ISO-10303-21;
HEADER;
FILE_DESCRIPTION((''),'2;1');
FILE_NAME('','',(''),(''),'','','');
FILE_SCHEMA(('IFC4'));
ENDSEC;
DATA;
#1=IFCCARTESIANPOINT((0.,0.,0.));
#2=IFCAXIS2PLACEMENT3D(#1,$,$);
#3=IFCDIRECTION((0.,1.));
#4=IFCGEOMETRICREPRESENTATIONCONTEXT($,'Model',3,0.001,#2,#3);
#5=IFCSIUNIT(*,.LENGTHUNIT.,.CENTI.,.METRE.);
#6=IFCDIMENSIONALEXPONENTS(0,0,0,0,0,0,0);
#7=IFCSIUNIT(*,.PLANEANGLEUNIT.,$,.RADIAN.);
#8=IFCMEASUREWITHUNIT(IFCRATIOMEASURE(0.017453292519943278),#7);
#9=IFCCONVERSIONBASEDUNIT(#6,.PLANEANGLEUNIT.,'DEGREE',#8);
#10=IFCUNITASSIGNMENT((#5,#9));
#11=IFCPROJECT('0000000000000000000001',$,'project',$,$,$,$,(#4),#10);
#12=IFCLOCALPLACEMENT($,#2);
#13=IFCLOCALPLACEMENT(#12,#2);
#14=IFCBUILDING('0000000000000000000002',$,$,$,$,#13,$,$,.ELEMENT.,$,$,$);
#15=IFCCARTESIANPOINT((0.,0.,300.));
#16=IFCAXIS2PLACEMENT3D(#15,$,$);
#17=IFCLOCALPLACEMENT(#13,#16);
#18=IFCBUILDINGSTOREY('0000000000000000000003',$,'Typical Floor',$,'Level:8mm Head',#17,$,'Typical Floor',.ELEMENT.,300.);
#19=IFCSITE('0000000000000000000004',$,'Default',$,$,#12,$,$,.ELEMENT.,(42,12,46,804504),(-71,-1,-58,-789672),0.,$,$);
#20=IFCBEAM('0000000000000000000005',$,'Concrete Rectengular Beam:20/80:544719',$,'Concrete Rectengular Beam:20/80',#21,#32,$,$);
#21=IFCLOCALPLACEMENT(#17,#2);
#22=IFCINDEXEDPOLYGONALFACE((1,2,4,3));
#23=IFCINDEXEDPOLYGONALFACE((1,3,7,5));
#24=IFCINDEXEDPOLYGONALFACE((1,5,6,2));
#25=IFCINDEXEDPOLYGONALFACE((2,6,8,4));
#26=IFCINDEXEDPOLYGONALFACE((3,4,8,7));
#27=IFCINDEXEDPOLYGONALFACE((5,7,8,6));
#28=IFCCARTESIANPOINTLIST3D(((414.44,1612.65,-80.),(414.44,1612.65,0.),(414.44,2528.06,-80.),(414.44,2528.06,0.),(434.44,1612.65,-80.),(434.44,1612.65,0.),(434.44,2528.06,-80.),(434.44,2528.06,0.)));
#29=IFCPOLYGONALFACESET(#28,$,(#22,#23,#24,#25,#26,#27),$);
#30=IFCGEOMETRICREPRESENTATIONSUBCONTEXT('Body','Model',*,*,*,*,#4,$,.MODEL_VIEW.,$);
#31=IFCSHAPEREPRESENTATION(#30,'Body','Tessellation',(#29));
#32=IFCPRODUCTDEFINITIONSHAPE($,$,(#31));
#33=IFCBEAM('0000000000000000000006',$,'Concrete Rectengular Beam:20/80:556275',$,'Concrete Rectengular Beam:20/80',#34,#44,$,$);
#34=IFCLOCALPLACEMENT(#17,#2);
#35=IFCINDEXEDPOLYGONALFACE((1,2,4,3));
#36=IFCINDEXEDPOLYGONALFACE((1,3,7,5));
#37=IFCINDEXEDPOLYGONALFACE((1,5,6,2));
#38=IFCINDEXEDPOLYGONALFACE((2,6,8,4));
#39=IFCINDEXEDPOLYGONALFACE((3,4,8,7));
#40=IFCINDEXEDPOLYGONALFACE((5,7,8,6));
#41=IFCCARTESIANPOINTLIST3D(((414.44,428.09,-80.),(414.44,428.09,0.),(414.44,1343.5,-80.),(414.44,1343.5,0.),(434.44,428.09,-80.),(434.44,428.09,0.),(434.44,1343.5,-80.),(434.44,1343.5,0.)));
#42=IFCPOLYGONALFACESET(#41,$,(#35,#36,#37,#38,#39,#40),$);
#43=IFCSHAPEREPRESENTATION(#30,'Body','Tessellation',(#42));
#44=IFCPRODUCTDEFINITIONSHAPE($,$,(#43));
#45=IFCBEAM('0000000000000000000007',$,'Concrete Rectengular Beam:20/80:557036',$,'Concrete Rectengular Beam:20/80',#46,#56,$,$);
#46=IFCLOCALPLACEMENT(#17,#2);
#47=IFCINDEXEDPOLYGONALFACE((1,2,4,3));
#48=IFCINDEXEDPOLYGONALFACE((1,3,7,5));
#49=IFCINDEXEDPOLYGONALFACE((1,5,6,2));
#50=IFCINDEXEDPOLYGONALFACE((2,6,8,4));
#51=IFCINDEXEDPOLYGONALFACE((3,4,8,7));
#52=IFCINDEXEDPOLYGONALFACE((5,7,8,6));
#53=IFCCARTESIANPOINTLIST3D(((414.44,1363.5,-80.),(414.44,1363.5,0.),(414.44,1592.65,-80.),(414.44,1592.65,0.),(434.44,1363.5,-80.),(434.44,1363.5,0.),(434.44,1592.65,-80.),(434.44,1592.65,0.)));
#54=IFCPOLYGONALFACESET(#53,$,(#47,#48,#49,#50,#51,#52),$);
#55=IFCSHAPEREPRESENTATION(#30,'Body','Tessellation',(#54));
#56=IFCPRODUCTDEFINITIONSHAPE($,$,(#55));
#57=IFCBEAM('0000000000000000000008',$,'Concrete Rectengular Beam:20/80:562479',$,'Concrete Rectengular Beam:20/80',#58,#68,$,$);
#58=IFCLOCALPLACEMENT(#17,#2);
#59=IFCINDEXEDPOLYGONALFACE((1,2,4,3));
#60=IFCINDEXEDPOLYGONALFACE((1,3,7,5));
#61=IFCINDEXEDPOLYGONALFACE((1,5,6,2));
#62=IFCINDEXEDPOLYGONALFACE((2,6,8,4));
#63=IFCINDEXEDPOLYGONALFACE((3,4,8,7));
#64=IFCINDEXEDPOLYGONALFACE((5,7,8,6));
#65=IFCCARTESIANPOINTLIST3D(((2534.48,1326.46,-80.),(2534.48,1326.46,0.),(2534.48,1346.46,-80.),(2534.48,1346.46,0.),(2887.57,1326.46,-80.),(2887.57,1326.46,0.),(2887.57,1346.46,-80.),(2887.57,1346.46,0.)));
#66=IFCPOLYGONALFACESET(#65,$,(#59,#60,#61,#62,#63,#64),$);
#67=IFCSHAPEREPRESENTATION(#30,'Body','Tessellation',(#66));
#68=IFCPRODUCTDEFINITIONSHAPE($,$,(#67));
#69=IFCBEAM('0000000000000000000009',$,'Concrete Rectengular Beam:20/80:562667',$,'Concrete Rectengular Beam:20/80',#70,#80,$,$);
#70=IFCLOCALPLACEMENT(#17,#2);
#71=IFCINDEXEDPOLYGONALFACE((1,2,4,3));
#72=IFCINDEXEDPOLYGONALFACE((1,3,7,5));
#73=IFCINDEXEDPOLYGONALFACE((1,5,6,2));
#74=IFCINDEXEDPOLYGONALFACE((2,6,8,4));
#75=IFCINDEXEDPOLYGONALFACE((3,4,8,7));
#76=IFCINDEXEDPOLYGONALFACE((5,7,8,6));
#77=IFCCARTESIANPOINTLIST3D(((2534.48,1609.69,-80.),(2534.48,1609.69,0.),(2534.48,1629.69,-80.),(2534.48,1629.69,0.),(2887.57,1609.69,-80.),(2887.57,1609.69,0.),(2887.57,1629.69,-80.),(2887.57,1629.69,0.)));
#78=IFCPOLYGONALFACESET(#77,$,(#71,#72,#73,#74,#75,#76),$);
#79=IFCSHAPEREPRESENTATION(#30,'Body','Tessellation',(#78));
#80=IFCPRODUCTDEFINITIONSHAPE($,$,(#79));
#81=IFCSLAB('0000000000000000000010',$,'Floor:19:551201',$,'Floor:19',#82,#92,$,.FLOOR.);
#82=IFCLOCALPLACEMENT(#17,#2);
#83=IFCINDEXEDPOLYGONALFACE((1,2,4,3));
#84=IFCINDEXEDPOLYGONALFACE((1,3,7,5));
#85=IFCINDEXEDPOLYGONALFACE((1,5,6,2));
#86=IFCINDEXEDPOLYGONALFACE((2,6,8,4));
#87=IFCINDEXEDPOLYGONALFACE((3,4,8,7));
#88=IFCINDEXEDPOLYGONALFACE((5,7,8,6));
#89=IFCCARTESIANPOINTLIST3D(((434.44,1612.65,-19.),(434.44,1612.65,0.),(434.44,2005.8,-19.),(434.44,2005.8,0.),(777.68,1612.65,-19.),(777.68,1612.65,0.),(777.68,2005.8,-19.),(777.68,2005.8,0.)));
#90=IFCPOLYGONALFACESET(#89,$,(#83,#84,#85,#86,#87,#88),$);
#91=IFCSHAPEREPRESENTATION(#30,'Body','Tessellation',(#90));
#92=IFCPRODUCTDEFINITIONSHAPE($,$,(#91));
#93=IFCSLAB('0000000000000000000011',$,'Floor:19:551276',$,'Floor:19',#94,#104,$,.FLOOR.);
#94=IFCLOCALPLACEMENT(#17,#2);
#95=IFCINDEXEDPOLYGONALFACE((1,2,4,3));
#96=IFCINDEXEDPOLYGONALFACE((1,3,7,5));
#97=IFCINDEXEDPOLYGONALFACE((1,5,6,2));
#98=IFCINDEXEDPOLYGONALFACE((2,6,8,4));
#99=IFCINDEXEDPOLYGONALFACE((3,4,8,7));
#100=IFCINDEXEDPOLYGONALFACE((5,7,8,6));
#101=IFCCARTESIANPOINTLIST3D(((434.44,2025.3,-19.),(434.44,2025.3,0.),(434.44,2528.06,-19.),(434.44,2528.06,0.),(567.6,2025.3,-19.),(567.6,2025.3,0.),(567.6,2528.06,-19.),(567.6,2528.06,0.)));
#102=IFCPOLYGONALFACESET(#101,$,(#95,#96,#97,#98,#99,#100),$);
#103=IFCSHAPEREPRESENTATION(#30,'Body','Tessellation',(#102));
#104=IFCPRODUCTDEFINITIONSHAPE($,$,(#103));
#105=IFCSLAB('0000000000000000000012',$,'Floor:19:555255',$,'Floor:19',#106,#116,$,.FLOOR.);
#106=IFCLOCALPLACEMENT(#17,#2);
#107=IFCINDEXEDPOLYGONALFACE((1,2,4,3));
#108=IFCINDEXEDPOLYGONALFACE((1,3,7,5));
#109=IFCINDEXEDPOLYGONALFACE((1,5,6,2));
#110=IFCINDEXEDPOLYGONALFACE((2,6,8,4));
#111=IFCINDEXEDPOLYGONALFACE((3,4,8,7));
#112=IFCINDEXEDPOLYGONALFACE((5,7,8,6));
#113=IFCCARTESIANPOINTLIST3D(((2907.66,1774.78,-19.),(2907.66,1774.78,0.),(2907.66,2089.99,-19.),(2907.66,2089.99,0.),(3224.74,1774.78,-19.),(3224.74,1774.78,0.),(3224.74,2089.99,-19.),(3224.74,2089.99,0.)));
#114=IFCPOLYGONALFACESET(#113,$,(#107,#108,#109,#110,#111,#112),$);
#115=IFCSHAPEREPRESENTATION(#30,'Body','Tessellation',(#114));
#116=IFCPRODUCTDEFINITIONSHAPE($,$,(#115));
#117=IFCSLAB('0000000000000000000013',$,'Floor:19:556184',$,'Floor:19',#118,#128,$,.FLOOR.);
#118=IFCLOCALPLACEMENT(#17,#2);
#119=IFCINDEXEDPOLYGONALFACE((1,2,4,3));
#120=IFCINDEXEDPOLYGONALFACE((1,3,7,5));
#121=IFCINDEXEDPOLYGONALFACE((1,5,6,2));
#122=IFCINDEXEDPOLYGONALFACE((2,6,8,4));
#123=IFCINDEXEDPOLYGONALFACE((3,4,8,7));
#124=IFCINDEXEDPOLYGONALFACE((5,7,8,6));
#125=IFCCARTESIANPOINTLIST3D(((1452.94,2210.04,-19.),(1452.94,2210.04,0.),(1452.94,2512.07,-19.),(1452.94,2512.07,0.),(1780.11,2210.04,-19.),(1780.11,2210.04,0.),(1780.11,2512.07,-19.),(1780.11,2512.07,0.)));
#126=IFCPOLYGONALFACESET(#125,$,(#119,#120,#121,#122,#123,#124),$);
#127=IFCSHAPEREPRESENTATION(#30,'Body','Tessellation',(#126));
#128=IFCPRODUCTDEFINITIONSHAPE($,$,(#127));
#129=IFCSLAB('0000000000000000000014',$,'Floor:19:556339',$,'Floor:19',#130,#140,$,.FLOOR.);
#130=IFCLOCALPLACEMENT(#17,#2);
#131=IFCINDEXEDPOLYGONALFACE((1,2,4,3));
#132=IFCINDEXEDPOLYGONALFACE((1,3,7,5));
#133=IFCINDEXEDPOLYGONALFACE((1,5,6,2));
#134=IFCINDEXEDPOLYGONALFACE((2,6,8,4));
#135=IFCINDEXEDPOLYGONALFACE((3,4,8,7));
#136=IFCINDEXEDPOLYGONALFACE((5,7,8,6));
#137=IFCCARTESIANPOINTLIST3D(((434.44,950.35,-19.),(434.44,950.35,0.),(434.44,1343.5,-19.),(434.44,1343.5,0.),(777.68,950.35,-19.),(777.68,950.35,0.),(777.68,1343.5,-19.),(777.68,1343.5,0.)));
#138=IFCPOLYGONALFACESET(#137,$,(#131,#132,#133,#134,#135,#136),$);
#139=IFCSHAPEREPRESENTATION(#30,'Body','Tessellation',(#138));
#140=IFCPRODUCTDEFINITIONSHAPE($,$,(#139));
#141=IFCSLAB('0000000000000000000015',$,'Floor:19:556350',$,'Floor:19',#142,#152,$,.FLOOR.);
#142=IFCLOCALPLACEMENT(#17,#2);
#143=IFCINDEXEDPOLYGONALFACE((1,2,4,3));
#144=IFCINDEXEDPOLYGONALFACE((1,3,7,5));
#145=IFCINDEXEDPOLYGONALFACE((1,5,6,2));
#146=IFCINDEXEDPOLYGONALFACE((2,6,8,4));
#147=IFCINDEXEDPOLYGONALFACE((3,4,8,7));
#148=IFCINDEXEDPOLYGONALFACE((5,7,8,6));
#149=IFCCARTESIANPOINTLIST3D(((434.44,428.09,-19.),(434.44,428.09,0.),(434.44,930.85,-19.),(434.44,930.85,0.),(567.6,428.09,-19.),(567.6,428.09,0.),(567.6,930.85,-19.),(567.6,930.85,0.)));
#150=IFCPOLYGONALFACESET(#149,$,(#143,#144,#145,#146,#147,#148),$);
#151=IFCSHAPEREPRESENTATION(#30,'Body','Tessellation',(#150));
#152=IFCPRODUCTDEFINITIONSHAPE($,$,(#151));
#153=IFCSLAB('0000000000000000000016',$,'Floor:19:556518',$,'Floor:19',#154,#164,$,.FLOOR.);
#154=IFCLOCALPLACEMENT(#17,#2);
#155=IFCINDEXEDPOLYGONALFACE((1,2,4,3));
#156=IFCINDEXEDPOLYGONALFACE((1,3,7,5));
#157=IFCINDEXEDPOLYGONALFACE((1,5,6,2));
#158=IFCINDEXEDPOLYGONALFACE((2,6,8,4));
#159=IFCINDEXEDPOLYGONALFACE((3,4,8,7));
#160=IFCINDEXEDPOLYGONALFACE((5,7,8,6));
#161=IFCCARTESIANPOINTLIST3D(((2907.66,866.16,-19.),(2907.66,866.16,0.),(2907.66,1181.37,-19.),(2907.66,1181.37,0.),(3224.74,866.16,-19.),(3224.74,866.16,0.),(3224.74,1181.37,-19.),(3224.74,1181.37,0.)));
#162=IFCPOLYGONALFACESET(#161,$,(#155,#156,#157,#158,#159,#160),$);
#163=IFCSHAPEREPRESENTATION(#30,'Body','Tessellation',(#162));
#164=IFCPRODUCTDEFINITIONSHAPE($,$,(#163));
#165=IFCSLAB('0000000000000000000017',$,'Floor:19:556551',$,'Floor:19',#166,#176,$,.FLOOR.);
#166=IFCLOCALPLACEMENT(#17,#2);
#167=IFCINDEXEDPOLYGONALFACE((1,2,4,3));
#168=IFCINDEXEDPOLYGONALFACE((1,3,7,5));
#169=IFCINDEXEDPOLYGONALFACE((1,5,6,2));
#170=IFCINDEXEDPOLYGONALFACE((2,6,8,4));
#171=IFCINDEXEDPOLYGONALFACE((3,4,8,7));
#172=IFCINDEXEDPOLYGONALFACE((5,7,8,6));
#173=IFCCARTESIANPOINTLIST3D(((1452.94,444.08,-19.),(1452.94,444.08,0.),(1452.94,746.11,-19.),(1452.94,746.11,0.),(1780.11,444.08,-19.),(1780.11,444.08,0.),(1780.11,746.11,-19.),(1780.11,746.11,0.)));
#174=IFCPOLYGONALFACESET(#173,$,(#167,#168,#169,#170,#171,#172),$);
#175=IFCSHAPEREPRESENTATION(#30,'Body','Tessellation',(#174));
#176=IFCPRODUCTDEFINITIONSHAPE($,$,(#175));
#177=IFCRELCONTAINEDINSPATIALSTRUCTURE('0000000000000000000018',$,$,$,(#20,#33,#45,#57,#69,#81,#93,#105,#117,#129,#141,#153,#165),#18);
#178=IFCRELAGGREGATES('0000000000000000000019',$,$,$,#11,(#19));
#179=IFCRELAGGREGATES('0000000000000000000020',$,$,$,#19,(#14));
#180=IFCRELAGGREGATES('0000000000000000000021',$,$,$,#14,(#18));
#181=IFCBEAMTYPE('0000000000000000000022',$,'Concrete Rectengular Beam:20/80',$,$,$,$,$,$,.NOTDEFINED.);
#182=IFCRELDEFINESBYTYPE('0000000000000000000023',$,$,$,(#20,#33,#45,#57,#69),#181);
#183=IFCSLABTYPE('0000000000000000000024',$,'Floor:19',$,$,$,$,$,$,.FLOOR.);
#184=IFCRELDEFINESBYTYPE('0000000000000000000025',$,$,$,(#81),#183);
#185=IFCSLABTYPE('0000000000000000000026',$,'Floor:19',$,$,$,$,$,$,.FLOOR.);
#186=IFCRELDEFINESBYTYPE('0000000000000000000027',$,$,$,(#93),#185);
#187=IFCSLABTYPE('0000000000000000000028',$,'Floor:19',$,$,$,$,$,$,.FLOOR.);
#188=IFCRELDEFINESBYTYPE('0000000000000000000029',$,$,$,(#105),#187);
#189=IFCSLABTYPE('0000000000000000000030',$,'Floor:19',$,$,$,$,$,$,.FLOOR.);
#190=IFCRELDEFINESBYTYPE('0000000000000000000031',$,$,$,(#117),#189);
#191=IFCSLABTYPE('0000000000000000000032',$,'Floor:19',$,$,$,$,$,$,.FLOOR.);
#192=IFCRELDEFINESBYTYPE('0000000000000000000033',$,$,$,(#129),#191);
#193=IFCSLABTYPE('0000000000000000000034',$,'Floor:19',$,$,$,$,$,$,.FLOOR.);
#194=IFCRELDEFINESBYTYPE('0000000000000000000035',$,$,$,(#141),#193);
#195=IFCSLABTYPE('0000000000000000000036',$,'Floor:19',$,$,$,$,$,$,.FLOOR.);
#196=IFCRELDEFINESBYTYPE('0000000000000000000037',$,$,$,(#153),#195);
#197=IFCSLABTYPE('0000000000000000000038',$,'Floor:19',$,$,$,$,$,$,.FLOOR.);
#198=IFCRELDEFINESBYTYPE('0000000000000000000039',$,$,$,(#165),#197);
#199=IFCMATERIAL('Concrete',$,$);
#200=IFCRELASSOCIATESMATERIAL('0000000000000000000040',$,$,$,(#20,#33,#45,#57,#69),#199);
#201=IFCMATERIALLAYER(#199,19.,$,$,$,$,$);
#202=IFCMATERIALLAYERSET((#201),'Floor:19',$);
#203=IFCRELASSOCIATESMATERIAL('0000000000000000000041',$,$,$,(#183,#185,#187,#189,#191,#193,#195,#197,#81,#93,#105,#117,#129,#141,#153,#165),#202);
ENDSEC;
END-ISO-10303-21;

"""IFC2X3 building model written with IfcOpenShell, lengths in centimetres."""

from ifc_helpers import new_model, entity, si_unit, converted_unit, direction, frame, frame_2d, origin, origin_2d_with_axis, place, context, subcontext, project, spatial, rectangle, extrude, material, layer, layer_set, layer_usage, type_object, element, save


model = new_model("IFC2X3")

# Units and contexts
model_context = context("Model", 3, precision=0.001, world=origin(), true_north=direction((0.0, 1.0)))
body_context = subcontext(model_context, "Body", "Model", "MODEL_VIEW")
ifc_project = project(units=[si_unit("LENGTHUNIT", "METRE", prefix="CENTI"), converted_unit("PLANEANGLEUNIT", "DEGREE", entity("IfcRatioMeasure", 0.017453292519943278), si_unit("PLANEANGLEUNIT", "RADIAN"), dimensions=[0, 0, 0, 0, 0, 0, 0])], contexts=[model_context])

# Site, building, storey
site_placement = place(None, origin())
site = spatial("IfcSite", under=ifc_project, at=site_placement, Name="Default", CompositionType="ELEMENT", RefLatitude=(42, 12, 46, 804504), RefLongitude=(-71, -1, -58, -789672), RefElevation=0.0)
building_placement = place(site_placement, origin())
building = spatial("IfcBuilding", under=site, at=building_placement, CompositionType="ELEMENT")
storey_placement = place(building_placement, frame((0.0, 0.0, 300.0)))
storey = spatial("IfcBuildingStorey", under=building, at=storey_placement, Name="Typical Floor", ObjectType="Level:8mm Head", LongName="Typical Floor", CompositionType="ELEMENT", Elevation=300.0)

# Beams
ifc_material = material(Name="Concrete")
beam_type_1 = type_object("IfcBeamType", Name="Concrete Rectengular Beam:20/80", PredefinedType="NOTDEFINED")
beam_1_placement = place(storey_placement, frame((424.44, 1602.65, 0.0), z_axis=(0.0, 0.0, 1.0), x_axis=(0.0, 1.0, 0.0)))
element("IfcBeam", 1, at=beam_1_placement, inside=storey, type_object=beam_type_1, material=ifc_material, Name="Concrete Rectengular Beam:20/80:544719", ObjectType="Concrete Rectengular Beam:20/80", context=body_context, shape_type="SweptSolid", body=[
    extrude(rectangle(XDim=80.0, YDim=20.0, at=frame_2d((0.0, 0.0), x_axis=(1.0, 0.0))), frame((10.0, 0.0, -40.0), z_axis=(1.0, 0.0, 0.0), x_axis=(0.0, 0.0, -1.0)), (0.0, 0.0, 1.0), 915.41),
])
beam_2_placement = place(storey_placement, frame((424.44, 1353.5, 0.0), z_axis=(0.0, 0.0, 1.0), x_axis=(0.0, -1.0, 0.0)))
element("IfcBeam", 2, at=beam_2_placement, inside=storey, type_object=beam_type_1, material=ifc_material, Name="Concrete Rectengular Beam:20/80:556275", ObjectType="Concrete Rectengular Beam:20/80", context=body_context, shape_type="SweptSolid", body=[
    extrude(rectangle(XDim=80.0, YDim=20.0, at=frame_2d((0.0, 0.0), x_axis=(1.0, 0.0))), frame((10.0, 0.0, -40.0), z_axis=(1.0, 0.0, 0.0), x_axis=(0.0, 0.0, -1.0)), (0.0, 0.0, 1.0), 915.41),
])
beam_3_placement = place(storey_placement, frame((424.44, 1353.5, 0.0), z_axis=(0.0, 0.0, 1.0), x_axis=(0.0, 1.0, 0.0)))
element("IfcBeam", 3, at=beam_3_placement, inside=storey, type_object=beam_type_1, material=ifc_material, Name="Concrete Rectengular Beam:20/80:557036", ObjectType="Concrete Rectengular Beam:20/80", context=body_context, shape_type="SweptSolid", body=[
    extrude(rectangle(XDim=80.0, YDim=20.0, at=frame_2d((0.0, 0.0), x_axis=(1.0, 0.0))), frame((10.0, 0.0, -40.0), z_axis=(1.0, 0.0, 0.0), x_axis=(0.0, 0.0, -1.0)), (0.0, 0.0, 1.0), 229.14),
])
beam_4_placement = place(storey_placement, frame((2897.57, 1336.46, 0.0), z_axis=(0.0, 0.0, 1.0), x_axis=(-1.0, 0.0, 0.0)))
element("IfcBeam", 4, at=beam_4_placement, inside=storey, type_object=beam_type_1, material=ifc_material, Name="Concrete Rectengular Beam:20/80:562479", ObjectType="Concrete Rectengular Beam:20/80", context=body_context, shape_type="SweptSolid", body=[
    extrude(rectangle(XDim=80.0, YDim=20.0, at=frame_2d((0.0, 0.0), x_axis=(1.0, 0.0))), frame((10.0, 0.0, -40.0), z_axis=(1.0, 0.0, 0.0), x_axis=(0.0, 0.0, -1.0)), (0.0, 0.0, 1.0), 353.09),
])
beam_5_placement = place(storey_placement, frame((2897.57, 1619.69, 0.0), z_axis=(0.0, 0.0, 1.0), x_axis=(-1.0, 0.0, 0.0)))
element("IfcBeam", 5, at=beam_5_placement, inside=storey, type_object=beam_type_1, material=ifc_material, Name="Concrete Rectengular Beam:20/80:562667", ObjectType="Concrete Rectengular Beam:20/80", context=body_context, shape_type="SweptSolid", body=[
    extrude(rectangle(XDim=80.0, YDim=20.0, at=frame_2d((0.0, 0.0), x_axis=(1.0, 0.0))), frame((10.0, 0.0, -40.0), z_axis=(1.0, 0.0, 0.0), x_axis=(0.0, 0.0, -1.0)), (0.0, 0.0, 1.0), 353.09),
])

# Slabs
ifc_layer = layer(ifc_material, 19.0)
ifc_layer_set = layer_set([ifc_layer], Name="Floor:19")
ifc_layer_usage_1 = layer_usage(ifc_layer_set, "AXIS3", "POSITIVE", 0.0)
slab_type_1 = type_object("IfcSlabType", Name="Floor:19", PredefinedType="FLOOR", material=ifc_layer_set)
slab_1_placement = place(storey_placement, origin())
element("IfcSlab", 6, at=slab_1_placement, inside=storey, type_object=slab_type_1, material=ifc_layer_usage_1, Name="Floor:19:551201", ObjectType="Floor:19", PredefinedType="FLOOR", context=body_context, shape_type="SweptSolid", body=[
    extrude(rectangle(XDim=393.16, YDim=343.24, at=frame_2d((0.0, 0.0), x_axis=(1.0, 0.0))), frame((606.06, 1809.23, 0.0), z_axis=(0.0, 0.0, -1.0), x_axis=(0.0, 1.0, 0.0)), (0.0, 0.0, 1.0), 19.0),
])
ifc_layer_usage_2 = layer_usage(ifc_layer_set, "AXIS3", "POSITIVE", 0.0)
slab_type_2 = type_object("IfcSlabType", Name="Floor:19", PredefinedType="FLOOR", material=ifc_layer_set)
slab_2_placement = place(storey_placement, origin())
element("IfcSlab", 7, at=slab_2_placement, inside=storey, type_object=slab_type_2, material=ifc_layer_usage_2, Name="Floor:19:551276", ObjectType="Floor:19", PredefinedType="FLOOR", context=body_context, shape_type="SweptSolid", body=[
    extrude(rectangle(XDim=502.76, YDim=133.17, at=origin_2d_with_axis()), frame((501.02, 2276.68, 0.0), z_axis=(0.0, 0.0, -1.0), x_axis=(0.0, 1.0, 0.0)), (0.0, 0.0, 1.0), 19.0),
])
ifc_layer_usage_3 = layer_usage(ifc_layer_set, "AXIS3", "POSITIVE", 0.0)
slab_type_3 = type_object("IfcSlabType", Name="Floor:19", PredefinedType="FLOOR", material=ifc_layer_set)
slab_3_placement = place(storey_placement, origin())
element("IfcSlab", 8, at=slab_3_placement, inside=storey, type_object=slab_type_3, material=ifc_layer_usage_3, Name="Floor:19:555255", ObjectType="Floor:19", PredefinedType="FLOOR", context=body_context, shape_type="SweptSolid", body=[
    extrude(rectangle(XDim=315.22, YDim=317.07, at=frame_2d((0.0, 0.0), x_axis=(1.0, 0.0))), frame((3066.2, 1932.39, 0.0), z_axis=(0.0, 0.0, -1.0), x_axis=(0.0, 1.0, 0.0)), (0.0, 0.0, 1.0), 19.0),
])
ifc_layer_usage_4 = layer_usage(ifc_layer_set, "AXIS3", "POSITIVE", 0.0)
slab_type_4 = type_object("IfcSlabType", Name="Floor:19", PredefinedType="FLOOR", material=ifc_layer_set)
slab_4_placement = place(storey_placement, origin())
element("IfcSlab", 9, at=slab_4_placement, inside=storey, type_object=slab_type_4, material=ifc_layer_usage_4, Name="Floor:19:556184", ObjectType="Floor:19", PredefinedType="FLOOR", context=body_context, shape_type="SweptSolid", body=[
    extrude(rectangle(XDim=302.03, YDim=327.17, at=origin_2d_with_axis()), frame((1616.53, 2361.06, 0.0), z_axis=(0.0, 0.0, -1.0), x_axis=(0.0, 1.0, 0.0)), (0.0, 0.0, 1.0), 19.0),
])
ifc_layer_usage_5 = layer_usage(ifc_layer_set, "AXIS3", "POSITIVE", 0.0)
slab_type_5 = type_object("IfcSlabType", Name="Floor:19", PredefinedType="FLOOR", material=ifc_layer_set)
slab_5_placement = place(storey_placement, origin())
element("IfcSlab", 10, at=slab_5_placement, inside=storey, type_object=slab_type_5, material=ifc_layer_usage_5, Name="Floor:19:556339", ObjectType="Floor:19", PredefinedType="FLOOR", context=body_context, shape_type="SweptSolid", body=[
    extrude(rectangle(XDim=393.16, YDim=343.24, at=frame_2d((0.0, 0.0), x_axis=(1.0, 0.0))), frame((606.06, 1146.92, 0.0), z_axis=(0.0, 0.0, -1.0), x_axis=(0.0, 1.0, 0.0)), (0.0, 0.0, 1.0), 19.0),
])
ifc_layer_usage_6 = layer_usage(ifc_layer_set, "AXIS3", "POSITIVE", 0.0)
slab_type_6 = type_object("IfcSlabType", Name="Floor:19", PredefinedType="FLOOR", material=ifc_layer_set)
slab_6_placement = place(storey_placement, origin())
element("IfcSlab", 11, at=slab_6_placement, inside=storey, type_object=slab_type_6, material=ifc_layer_usage_6, Name="Floor:19:556350", ObjectType="Floor:19", PredefinedType="FLOOR", context=body_context, shape_type="SweptSolid", body=[
    extrude(rectangle(XDim=502.76, YDim=133.17, at=origin_2d_with_axis()), frame((501.02, 679.47, 0.0), z_axis=(0.0, 0.0, -1.0), x_axis=(0.0, 1.0, 0.0)), (0.0, 0.0, 1.0), 19.0),
])
ifc_layer_usage_7 = layer_usage(ifc_layer_set, "AXIS3", "POSITIVE", 0.0)
slab_type_7 = type_object("IfcSlabType", Name="Floor:19", PredefinedType="FLOOR", material=ifc_layer_set)
slab_7_placement = place(storey_placement, origin())
element("IfcSlab", 12, at=slab_7_placement, inside=storey, type_object=slab_type_7, material=ifc_layer_usage_7, Name="Floor:19:556518", ObjectType="Floor:19", PredefinedType="FLOOR", context=body_context, shape_type="SweptSolid", body=[
    extrude(rectangle(XDim=315.22, YDim=317.07, at=frame_2d((0.0, 0.0), x_axis=(1.0, 0.0))), frame((3066.2, 1023.76, 0.0), z_axis=(0.0, 0.0, -1.0), x_axis=(0.0, 1.0, 0.0)), (0.0, 0.0, 1.0), 19.0),
])
ifc_layer_usage_8 = layer_usage(ifc_layer_set, "AXIS3", "POSITIVE", 0.0)
slab_type_8 = type_object("IfcSlabType", Name="Floor:19", PredefinedType="FLOOR", material=ifc_layer_set)
slab_8_placement = place(storey_placement, origin())
element("IfcSlab", 13, at=slab_8_placement, inside=storey, type_object=slab_type_8, material=ifc_layer_usage_8, Name="Floor:19:556551", ObjectType="Floor:19", PredefinedType="FLOOR", context=body_context, shape_type="SweptSolid", body=[
    extrude(rectangle(XDim=302.03, YDim=327.17, at=frame_2d((0.0, 0.0), x_axis=(1.0, 0.0))), frame((1616.53, 595.09, 0.0), z_axis=(0.0, 0.0, -1.0), x_axis=(0.0, 1.0, 0.0)), (0.0, 0.0, 1.0), 19.0),
])

save(model, "model.ifc")
